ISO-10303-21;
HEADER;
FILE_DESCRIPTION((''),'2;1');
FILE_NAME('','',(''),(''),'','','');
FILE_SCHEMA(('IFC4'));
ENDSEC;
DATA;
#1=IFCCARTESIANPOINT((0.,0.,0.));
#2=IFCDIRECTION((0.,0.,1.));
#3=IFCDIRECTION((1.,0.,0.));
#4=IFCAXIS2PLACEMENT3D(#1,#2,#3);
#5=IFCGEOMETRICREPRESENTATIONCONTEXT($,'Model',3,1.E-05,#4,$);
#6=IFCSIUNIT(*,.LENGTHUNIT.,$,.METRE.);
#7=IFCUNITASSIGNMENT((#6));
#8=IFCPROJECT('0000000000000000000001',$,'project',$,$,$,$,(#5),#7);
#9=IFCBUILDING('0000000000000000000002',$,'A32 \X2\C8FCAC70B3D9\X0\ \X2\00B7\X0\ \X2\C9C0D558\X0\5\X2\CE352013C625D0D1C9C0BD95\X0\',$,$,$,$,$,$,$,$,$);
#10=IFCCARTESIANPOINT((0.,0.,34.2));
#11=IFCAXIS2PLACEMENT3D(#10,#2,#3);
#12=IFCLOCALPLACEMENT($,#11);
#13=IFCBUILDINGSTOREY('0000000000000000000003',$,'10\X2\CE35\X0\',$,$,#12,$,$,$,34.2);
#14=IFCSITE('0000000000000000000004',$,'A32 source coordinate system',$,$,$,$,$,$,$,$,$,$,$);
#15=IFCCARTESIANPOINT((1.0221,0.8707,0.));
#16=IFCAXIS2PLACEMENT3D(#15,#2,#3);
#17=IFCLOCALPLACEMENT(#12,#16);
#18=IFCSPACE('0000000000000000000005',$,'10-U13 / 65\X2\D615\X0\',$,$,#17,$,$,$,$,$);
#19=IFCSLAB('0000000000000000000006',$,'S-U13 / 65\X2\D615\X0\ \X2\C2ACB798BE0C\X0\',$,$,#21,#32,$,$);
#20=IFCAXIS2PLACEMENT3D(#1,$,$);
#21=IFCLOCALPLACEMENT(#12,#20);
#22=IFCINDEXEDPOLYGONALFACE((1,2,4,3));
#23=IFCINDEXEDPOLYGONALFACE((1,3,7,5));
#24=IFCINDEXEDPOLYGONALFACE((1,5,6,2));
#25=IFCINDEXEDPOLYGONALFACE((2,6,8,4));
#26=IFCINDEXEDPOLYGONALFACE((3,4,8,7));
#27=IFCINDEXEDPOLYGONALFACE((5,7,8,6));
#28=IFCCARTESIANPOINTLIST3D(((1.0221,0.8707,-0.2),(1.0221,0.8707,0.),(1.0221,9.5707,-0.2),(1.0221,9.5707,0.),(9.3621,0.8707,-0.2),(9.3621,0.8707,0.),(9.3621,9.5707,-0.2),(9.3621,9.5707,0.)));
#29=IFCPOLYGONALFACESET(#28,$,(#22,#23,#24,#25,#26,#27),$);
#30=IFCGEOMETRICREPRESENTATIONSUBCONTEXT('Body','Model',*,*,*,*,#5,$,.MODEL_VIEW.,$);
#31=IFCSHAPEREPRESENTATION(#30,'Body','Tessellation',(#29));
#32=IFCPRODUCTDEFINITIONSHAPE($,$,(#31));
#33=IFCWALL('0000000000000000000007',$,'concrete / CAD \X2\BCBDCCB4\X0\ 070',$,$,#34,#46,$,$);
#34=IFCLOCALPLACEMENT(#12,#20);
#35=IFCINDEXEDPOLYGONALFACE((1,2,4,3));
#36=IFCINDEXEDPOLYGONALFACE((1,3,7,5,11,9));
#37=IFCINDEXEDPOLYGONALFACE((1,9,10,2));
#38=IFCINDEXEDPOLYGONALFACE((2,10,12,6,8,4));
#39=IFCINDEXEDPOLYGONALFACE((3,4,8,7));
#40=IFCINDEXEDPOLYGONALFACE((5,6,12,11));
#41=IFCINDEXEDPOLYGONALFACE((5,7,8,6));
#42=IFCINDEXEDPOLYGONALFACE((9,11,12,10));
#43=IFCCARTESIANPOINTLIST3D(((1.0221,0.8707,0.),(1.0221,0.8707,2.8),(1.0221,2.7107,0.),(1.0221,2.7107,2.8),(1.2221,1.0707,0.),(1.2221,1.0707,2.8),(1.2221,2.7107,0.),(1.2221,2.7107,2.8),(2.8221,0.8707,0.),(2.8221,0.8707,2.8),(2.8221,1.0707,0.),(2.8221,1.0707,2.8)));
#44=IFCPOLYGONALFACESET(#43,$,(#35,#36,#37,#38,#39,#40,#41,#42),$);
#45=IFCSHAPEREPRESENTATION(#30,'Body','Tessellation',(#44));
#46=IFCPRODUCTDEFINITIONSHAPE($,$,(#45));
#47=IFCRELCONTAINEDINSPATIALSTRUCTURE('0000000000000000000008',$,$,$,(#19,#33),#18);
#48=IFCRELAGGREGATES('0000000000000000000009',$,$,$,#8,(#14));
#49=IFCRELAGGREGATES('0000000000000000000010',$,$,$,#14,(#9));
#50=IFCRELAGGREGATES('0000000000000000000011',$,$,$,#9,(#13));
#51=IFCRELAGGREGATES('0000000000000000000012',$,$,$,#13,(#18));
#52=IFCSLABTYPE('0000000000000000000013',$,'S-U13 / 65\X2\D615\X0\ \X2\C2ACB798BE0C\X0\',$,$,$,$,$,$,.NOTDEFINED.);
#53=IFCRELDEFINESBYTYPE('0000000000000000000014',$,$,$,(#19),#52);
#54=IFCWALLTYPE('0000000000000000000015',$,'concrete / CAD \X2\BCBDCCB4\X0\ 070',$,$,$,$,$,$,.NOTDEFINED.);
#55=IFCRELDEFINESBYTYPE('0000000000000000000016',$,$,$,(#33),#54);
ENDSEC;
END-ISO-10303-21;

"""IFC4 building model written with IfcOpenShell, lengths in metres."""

from ifc_helpers import new_model, si_unit, frame, origin, origin_with_axes, place, context, subcontext, project, spatial, polyline, outline, extrude, source, transform, mapped, type_object, type_shapes, element, save


model = new_model("IFC4")

# Units and contexts
model_context = context("Model", 3, precision=1e-05, world=origin_with_axes())
body_context = subcontext(model_context, "Body", "Model", "MODEL_VIEW")
ifc_project = project(units=[si_unit("LENGTHUNIT", "METRE")], contexts=[model_context])

# Site, building, storey, space
storey_placement = place(None, frame((0.0, 0.0, 34.2), z_axis=(0.0, 0.0, 1.0), x_axis=(1.0, 0.0, 0.0)))
space_placement = place(storey_placement, frame((1.0221, 0.8707, 0.0), z_axis=(0.0, 0.0, 1.0), x_axis=(1.0, 0.0, 0.0)))
site = spatial("IfcSite", under=ifc_project, Name="A32 source coordinate system")
building = spatial("IfcBuilding", under=site, Name="A32 주거동 · 지하5층–옥탑지붕")
storey = spatial("IfcBuildingStorey", under=building, at=storey_placement, Name="10층", Elevation=34.2)
space = spatial("IfcSpace", under=storey, at=space_placement, Name="10-U13 / 65형")

# Slab
slab_type = type_object("IfcSlabType", Name="S-U13 / 65형 슬래브", PredefinedType="NOTDEFINED")
shared_shape_1 = source(origin(), body_context, "Body", "SweptSolid", [
    extrude(outline(polyline([(0.0, 0.0), (0.0, 8.7), (8.34, 8.7), (8.34, 0.0), (0.0, 0.0)])), frame((0.0, 0.0, -0.2)), (0.0, 0.0, 1.0), 0.2),
])
type_shapes(slab_type, [shared_shape_1])
slab_placement = place(space_placement, origin_with_axes())
element("IfcSlab", 1, at=slab_placement, inside=space, type_object=slab_type, Name="S-U13 / 65형 슬래브", context=body_context, shape_type="MappedRepresentation", body=[
    mapped(shared_shape_1, transform((0.0, 0.0, 0.0), scale=1.0)),
])

# Wall
wall_type_1 = type_object("IfcWallType", Name="concrete / CAD 벽체 070", PredefinedType="NOTDEFINED")
shared_shape_2 = source(origin(), body_context, "Body", "SweptSolid", [
    extrude(outline(polyline([(0.2, 1.84), (0.2, 0.2), (1.8, 0.2), (1.8, 0.0), (0.0, 0.0), (0.0, 1.84), (0.2, 1.84)])), origin(), (0.0, 0.0, 1.0), 2.8),
])
type_shapes(wall_type_1, [shared_shape_2])
wall_1_placement = place(space_placement, origin_with_axes())
element("IfcWall", 2, at=wall_1_placement, inside=space, type_object=wall_type_1, Name="concrete / CAD 벽체 070", context=body_context, shape_type="MappedRepresentation", body=[
    mapped(shared_shape_2, transform((0.0, 0.0, 0.0), scale=1.0)),
])

save(model, "model.ifc")
